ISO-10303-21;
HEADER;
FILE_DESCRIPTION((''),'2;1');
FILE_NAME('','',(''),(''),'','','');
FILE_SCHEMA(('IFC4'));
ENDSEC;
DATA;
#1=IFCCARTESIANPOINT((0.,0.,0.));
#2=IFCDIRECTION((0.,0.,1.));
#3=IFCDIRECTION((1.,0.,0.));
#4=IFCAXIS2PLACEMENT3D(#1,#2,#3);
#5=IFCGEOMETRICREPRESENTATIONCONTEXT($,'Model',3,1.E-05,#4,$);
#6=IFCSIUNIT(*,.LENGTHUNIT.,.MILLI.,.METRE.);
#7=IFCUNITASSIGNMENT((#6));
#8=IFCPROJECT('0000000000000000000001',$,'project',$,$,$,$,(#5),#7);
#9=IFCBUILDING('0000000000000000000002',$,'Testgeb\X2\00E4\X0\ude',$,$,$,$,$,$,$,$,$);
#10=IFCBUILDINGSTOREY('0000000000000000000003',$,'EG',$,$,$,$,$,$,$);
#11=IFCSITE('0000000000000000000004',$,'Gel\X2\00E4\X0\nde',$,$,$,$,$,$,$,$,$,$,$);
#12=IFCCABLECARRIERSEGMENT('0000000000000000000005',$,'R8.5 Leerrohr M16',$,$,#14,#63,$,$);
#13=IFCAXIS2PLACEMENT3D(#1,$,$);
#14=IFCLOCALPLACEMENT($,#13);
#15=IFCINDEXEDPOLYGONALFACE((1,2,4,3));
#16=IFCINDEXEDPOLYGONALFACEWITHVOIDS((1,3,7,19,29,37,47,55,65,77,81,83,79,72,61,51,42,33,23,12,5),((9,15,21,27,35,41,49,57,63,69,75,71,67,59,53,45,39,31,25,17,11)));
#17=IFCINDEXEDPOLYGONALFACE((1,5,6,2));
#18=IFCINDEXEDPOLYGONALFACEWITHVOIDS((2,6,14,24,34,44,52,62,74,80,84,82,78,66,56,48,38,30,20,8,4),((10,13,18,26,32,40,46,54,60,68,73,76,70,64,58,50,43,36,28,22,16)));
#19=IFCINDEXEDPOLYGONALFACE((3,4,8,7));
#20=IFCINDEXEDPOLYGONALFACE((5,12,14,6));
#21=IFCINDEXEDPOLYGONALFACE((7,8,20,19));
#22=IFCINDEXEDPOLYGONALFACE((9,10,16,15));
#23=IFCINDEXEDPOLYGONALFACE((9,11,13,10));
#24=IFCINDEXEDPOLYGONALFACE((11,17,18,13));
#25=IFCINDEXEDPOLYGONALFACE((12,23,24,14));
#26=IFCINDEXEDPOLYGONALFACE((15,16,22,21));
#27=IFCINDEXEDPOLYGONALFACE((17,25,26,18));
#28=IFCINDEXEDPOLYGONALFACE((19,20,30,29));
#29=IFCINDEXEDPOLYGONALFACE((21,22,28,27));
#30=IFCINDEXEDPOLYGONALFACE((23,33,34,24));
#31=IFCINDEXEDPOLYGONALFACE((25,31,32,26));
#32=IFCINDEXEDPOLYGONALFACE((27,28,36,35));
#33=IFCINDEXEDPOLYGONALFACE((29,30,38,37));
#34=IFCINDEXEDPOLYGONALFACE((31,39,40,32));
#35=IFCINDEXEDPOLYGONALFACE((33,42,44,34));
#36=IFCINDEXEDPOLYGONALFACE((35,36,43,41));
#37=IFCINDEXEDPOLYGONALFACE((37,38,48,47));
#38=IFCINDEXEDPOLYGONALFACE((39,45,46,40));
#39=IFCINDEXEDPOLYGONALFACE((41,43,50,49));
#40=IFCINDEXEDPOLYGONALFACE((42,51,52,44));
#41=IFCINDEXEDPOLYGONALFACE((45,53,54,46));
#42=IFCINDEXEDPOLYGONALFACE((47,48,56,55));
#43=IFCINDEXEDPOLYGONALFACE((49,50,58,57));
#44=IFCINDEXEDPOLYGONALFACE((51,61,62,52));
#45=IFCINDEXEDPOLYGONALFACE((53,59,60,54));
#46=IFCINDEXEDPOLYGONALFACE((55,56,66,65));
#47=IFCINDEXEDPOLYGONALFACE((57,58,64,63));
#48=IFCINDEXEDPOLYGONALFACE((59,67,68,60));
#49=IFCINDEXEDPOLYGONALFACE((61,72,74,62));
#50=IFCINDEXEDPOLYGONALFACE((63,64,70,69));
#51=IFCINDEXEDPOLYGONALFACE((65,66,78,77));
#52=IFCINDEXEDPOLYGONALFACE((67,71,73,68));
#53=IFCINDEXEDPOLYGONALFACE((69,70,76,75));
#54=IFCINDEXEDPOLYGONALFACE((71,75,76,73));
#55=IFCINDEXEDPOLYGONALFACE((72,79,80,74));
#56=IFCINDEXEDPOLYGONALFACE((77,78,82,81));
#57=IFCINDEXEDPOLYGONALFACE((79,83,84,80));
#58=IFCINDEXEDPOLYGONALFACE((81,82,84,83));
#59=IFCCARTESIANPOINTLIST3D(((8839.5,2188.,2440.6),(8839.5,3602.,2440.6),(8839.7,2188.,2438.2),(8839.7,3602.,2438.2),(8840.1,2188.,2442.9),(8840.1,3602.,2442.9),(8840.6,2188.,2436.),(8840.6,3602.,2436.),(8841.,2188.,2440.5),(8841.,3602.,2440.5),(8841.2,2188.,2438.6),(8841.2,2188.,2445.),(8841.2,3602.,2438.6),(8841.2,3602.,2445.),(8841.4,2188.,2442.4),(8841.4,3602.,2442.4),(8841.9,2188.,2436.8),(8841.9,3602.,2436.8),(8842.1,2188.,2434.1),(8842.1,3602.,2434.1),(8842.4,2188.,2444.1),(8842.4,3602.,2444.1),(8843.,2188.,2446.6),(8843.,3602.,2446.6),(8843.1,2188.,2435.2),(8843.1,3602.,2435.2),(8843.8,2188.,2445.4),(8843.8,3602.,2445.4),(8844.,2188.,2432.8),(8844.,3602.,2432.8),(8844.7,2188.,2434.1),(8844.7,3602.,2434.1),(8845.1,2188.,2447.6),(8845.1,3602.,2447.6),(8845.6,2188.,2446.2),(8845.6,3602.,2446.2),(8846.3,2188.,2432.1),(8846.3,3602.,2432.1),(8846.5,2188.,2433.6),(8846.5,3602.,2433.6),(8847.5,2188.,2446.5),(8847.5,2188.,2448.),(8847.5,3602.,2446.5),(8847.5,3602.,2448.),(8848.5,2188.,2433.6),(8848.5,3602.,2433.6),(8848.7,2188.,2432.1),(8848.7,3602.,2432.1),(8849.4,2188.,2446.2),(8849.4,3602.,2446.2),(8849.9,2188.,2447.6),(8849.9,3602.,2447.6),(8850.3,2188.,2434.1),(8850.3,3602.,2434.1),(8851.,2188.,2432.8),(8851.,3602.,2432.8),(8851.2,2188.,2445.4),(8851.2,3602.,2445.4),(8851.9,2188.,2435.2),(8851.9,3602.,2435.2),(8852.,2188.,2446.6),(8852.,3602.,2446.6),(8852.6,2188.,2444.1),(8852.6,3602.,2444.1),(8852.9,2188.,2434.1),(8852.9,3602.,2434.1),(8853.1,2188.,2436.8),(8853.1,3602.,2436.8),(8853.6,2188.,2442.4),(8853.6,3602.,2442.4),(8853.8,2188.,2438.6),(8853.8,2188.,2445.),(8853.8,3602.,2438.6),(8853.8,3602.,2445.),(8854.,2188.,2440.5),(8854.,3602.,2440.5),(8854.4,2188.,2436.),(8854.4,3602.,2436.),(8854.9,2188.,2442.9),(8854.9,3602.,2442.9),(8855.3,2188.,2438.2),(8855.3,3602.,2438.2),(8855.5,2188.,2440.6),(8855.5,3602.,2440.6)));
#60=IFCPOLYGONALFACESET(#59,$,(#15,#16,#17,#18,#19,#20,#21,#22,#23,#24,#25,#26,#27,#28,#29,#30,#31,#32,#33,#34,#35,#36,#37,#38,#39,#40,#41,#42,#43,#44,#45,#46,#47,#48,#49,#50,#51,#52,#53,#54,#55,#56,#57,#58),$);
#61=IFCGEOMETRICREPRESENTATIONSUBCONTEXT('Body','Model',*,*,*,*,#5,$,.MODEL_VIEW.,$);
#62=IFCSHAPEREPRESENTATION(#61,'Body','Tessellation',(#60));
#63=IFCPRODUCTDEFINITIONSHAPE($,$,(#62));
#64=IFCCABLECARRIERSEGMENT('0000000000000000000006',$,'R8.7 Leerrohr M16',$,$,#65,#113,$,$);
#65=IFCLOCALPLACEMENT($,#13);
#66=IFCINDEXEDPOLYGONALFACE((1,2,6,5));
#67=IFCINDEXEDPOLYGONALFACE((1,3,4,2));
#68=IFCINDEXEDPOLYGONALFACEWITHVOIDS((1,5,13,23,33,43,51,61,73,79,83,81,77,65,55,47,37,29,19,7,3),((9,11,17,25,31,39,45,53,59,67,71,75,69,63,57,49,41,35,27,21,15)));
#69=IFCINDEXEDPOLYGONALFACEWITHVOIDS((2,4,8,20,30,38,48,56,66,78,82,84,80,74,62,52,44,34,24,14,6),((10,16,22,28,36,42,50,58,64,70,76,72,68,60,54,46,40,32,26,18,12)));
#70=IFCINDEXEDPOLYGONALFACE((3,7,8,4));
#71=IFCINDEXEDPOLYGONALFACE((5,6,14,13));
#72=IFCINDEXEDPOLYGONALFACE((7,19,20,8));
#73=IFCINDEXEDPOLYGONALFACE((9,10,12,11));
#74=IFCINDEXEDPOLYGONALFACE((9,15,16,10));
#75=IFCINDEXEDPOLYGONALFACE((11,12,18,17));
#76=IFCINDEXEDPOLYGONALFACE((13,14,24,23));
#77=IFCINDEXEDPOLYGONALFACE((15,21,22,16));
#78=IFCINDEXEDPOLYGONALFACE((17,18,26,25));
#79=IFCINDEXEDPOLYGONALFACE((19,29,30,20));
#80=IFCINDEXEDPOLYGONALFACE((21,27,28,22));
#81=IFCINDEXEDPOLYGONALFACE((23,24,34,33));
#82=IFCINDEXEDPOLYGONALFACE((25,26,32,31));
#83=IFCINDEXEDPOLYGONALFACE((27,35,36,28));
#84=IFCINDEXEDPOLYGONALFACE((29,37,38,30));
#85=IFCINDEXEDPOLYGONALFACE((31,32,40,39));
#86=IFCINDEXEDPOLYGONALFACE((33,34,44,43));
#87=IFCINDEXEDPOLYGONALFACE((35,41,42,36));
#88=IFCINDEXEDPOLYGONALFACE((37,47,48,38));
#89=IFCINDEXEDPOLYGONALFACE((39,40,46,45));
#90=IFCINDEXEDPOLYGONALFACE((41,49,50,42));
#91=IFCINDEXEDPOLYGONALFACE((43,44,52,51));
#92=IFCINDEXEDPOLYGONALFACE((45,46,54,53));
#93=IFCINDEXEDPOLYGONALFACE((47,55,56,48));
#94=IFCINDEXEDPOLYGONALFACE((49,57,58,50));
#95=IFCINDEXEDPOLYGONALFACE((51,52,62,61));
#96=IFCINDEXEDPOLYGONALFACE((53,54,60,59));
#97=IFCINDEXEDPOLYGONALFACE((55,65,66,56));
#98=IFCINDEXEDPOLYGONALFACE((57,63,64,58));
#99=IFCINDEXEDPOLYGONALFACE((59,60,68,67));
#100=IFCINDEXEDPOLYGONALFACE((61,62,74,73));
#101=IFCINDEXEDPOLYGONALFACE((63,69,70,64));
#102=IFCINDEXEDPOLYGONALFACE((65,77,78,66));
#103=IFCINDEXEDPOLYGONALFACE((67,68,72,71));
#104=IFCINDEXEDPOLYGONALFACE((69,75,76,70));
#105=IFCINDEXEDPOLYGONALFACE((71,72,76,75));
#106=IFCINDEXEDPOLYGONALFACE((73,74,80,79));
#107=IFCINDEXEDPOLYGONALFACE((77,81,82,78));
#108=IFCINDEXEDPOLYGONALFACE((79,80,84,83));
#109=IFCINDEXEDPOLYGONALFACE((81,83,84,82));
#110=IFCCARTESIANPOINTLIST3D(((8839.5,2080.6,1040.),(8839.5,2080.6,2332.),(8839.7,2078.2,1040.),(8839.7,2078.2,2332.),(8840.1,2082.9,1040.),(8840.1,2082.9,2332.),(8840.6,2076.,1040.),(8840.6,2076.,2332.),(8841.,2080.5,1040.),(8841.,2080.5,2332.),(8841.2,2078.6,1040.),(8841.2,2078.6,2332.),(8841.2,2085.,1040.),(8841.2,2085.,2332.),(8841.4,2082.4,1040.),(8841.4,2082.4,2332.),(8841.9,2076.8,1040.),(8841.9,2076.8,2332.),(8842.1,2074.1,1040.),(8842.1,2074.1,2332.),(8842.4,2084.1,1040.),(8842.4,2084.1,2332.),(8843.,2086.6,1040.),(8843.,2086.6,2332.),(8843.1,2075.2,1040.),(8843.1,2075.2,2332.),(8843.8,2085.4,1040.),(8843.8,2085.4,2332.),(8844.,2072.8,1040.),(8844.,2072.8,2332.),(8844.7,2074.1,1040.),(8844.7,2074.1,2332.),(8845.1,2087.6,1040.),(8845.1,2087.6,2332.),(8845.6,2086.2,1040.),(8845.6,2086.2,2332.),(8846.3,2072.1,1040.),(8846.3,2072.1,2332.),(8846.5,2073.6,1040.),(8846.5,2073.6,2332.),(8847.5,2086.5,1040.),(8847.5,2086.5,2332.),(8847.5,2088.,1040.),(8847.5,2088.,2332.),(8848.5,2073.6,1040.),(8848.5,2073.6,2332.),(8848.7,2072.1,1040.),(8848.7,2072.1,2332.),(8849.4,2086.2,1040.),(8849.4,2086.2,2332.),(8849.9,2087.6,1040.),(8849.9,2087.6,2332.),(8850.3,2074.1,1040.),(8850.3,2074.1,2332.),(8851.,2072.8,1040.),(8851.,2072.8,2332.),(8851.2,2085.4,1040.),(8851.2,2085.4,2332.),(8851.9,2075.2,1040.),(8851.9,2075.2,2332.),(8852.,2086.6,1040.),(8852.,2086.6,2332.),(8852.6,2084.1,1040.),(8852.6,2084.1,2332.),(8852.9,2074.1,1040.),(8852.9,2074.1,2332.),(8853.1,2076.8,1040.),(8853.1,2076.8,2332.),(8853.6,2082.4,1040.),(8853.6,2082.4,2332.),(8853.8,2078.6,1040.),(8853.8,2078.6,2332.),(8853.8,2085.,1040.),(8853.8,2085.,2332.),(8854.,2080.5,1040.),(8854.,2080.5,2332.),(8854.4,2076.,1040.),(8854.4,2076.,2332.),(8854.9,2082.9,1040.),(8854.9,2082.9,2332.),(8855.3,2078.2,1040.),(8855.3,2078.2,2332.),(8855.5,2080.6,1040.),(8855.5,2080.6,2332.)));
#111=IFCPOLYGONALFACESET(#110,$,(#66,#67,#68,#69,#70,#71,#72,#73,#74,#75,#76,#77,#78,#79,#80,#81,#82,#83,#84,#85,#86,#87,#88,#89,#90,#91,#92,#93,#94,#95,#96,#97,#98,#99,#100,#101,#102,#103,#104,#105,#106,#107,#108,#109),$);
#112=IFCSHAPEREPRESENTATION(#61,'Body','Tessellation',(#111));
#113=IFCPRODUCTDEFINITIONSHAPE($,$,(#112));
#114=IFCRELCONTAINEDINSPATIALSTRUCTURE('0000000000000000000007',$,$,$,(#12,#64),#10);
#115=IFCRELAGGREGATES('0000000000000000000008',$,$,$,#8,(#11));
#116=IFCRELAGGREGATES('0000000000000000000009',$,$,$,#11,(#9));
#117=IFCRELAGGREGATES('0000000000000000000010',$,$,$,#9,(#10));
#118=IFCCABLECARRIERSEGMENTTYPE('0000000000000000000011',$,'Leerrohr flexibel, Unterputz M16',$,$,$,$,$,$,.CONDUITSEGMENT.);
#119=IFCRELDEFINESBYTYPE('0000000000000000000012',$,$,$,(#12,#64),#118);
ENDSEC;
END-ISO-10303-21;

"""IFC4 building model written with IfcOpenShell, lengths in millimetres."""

from ifc_helpers import new_model, si_unit, frame, origin_with_axes, place, context, subcontext, project, spatial, hollow_circle, extrude, type_object, element, save


model = new_model("IFC4")

# Units and contexts
model_context = context("Model", 3, precision=1e-05, world=origin_with_axes())
body_context = subcontext(model_context, "Body", "Model", "MODEL_VIEW")
ifc_project = project(units=[si_unit("LENGTHUNIT", "METRE", prefix="MILLI")], contexts=[model_context])

# Site, building, storey
site = spatial("IfcSite", under=ifc_project, Name="Gelände")
building = spatial("IfcBuilding", under=site, Name="Testgebäude")
storey = spatial("IfcBuildingStorey", under=building, Name="EG")

# Cable carrier segments
cable_carrier_segment_type_1 = type_object("IfcCableCarrierSegmentType", Name="Leerrohr flexibel, Unterputz M16", PredefinedType="CONDUITSEGMENT")
cable_carrier_segment_1_placement = place(None, frame((8847.5, 3602.0, 2440.0), z_axis=(0.0, -1.0, 0.0), x_axis=(0.0, 0.0, 1.0)))
element("IfcCableCarrierSegment", 1, at=cable_carrier_segment_1_placement, inside=storey, type_object=cable_carrier_segment_type_1, Name="R8.5 Leerrohr M16", context=body_context, shape_type="SweptSolid", body=[
    extrude(hollow_circle(Radius=8.0, WallThickness=1.5), None, (0.0, 0.0, 1.0), 1414.0),
])
cable_carrier_segment_2_placement = place(None, frame((8847.5, 2080.0, 2332.0), z_axis=(0.0, 0.0, -1.0), x_axis=(0.0, 1.0, 0.0)))
element("IfcCableCarrierSegment", 2, at=cable_carrier_segment_2_placement, inside=storey, type_object=cable_carrier_segment_type_1, Name="R8.7 Leerrohr M16", context=body_context, shape_type="SweptSolid", body=[
    extrude(hollow_circle(Radius=8.0, WallThickness=1.5), None, (0.0, 0.0, 1.0), 1292.0),
])

save(model, "model.ifc")
